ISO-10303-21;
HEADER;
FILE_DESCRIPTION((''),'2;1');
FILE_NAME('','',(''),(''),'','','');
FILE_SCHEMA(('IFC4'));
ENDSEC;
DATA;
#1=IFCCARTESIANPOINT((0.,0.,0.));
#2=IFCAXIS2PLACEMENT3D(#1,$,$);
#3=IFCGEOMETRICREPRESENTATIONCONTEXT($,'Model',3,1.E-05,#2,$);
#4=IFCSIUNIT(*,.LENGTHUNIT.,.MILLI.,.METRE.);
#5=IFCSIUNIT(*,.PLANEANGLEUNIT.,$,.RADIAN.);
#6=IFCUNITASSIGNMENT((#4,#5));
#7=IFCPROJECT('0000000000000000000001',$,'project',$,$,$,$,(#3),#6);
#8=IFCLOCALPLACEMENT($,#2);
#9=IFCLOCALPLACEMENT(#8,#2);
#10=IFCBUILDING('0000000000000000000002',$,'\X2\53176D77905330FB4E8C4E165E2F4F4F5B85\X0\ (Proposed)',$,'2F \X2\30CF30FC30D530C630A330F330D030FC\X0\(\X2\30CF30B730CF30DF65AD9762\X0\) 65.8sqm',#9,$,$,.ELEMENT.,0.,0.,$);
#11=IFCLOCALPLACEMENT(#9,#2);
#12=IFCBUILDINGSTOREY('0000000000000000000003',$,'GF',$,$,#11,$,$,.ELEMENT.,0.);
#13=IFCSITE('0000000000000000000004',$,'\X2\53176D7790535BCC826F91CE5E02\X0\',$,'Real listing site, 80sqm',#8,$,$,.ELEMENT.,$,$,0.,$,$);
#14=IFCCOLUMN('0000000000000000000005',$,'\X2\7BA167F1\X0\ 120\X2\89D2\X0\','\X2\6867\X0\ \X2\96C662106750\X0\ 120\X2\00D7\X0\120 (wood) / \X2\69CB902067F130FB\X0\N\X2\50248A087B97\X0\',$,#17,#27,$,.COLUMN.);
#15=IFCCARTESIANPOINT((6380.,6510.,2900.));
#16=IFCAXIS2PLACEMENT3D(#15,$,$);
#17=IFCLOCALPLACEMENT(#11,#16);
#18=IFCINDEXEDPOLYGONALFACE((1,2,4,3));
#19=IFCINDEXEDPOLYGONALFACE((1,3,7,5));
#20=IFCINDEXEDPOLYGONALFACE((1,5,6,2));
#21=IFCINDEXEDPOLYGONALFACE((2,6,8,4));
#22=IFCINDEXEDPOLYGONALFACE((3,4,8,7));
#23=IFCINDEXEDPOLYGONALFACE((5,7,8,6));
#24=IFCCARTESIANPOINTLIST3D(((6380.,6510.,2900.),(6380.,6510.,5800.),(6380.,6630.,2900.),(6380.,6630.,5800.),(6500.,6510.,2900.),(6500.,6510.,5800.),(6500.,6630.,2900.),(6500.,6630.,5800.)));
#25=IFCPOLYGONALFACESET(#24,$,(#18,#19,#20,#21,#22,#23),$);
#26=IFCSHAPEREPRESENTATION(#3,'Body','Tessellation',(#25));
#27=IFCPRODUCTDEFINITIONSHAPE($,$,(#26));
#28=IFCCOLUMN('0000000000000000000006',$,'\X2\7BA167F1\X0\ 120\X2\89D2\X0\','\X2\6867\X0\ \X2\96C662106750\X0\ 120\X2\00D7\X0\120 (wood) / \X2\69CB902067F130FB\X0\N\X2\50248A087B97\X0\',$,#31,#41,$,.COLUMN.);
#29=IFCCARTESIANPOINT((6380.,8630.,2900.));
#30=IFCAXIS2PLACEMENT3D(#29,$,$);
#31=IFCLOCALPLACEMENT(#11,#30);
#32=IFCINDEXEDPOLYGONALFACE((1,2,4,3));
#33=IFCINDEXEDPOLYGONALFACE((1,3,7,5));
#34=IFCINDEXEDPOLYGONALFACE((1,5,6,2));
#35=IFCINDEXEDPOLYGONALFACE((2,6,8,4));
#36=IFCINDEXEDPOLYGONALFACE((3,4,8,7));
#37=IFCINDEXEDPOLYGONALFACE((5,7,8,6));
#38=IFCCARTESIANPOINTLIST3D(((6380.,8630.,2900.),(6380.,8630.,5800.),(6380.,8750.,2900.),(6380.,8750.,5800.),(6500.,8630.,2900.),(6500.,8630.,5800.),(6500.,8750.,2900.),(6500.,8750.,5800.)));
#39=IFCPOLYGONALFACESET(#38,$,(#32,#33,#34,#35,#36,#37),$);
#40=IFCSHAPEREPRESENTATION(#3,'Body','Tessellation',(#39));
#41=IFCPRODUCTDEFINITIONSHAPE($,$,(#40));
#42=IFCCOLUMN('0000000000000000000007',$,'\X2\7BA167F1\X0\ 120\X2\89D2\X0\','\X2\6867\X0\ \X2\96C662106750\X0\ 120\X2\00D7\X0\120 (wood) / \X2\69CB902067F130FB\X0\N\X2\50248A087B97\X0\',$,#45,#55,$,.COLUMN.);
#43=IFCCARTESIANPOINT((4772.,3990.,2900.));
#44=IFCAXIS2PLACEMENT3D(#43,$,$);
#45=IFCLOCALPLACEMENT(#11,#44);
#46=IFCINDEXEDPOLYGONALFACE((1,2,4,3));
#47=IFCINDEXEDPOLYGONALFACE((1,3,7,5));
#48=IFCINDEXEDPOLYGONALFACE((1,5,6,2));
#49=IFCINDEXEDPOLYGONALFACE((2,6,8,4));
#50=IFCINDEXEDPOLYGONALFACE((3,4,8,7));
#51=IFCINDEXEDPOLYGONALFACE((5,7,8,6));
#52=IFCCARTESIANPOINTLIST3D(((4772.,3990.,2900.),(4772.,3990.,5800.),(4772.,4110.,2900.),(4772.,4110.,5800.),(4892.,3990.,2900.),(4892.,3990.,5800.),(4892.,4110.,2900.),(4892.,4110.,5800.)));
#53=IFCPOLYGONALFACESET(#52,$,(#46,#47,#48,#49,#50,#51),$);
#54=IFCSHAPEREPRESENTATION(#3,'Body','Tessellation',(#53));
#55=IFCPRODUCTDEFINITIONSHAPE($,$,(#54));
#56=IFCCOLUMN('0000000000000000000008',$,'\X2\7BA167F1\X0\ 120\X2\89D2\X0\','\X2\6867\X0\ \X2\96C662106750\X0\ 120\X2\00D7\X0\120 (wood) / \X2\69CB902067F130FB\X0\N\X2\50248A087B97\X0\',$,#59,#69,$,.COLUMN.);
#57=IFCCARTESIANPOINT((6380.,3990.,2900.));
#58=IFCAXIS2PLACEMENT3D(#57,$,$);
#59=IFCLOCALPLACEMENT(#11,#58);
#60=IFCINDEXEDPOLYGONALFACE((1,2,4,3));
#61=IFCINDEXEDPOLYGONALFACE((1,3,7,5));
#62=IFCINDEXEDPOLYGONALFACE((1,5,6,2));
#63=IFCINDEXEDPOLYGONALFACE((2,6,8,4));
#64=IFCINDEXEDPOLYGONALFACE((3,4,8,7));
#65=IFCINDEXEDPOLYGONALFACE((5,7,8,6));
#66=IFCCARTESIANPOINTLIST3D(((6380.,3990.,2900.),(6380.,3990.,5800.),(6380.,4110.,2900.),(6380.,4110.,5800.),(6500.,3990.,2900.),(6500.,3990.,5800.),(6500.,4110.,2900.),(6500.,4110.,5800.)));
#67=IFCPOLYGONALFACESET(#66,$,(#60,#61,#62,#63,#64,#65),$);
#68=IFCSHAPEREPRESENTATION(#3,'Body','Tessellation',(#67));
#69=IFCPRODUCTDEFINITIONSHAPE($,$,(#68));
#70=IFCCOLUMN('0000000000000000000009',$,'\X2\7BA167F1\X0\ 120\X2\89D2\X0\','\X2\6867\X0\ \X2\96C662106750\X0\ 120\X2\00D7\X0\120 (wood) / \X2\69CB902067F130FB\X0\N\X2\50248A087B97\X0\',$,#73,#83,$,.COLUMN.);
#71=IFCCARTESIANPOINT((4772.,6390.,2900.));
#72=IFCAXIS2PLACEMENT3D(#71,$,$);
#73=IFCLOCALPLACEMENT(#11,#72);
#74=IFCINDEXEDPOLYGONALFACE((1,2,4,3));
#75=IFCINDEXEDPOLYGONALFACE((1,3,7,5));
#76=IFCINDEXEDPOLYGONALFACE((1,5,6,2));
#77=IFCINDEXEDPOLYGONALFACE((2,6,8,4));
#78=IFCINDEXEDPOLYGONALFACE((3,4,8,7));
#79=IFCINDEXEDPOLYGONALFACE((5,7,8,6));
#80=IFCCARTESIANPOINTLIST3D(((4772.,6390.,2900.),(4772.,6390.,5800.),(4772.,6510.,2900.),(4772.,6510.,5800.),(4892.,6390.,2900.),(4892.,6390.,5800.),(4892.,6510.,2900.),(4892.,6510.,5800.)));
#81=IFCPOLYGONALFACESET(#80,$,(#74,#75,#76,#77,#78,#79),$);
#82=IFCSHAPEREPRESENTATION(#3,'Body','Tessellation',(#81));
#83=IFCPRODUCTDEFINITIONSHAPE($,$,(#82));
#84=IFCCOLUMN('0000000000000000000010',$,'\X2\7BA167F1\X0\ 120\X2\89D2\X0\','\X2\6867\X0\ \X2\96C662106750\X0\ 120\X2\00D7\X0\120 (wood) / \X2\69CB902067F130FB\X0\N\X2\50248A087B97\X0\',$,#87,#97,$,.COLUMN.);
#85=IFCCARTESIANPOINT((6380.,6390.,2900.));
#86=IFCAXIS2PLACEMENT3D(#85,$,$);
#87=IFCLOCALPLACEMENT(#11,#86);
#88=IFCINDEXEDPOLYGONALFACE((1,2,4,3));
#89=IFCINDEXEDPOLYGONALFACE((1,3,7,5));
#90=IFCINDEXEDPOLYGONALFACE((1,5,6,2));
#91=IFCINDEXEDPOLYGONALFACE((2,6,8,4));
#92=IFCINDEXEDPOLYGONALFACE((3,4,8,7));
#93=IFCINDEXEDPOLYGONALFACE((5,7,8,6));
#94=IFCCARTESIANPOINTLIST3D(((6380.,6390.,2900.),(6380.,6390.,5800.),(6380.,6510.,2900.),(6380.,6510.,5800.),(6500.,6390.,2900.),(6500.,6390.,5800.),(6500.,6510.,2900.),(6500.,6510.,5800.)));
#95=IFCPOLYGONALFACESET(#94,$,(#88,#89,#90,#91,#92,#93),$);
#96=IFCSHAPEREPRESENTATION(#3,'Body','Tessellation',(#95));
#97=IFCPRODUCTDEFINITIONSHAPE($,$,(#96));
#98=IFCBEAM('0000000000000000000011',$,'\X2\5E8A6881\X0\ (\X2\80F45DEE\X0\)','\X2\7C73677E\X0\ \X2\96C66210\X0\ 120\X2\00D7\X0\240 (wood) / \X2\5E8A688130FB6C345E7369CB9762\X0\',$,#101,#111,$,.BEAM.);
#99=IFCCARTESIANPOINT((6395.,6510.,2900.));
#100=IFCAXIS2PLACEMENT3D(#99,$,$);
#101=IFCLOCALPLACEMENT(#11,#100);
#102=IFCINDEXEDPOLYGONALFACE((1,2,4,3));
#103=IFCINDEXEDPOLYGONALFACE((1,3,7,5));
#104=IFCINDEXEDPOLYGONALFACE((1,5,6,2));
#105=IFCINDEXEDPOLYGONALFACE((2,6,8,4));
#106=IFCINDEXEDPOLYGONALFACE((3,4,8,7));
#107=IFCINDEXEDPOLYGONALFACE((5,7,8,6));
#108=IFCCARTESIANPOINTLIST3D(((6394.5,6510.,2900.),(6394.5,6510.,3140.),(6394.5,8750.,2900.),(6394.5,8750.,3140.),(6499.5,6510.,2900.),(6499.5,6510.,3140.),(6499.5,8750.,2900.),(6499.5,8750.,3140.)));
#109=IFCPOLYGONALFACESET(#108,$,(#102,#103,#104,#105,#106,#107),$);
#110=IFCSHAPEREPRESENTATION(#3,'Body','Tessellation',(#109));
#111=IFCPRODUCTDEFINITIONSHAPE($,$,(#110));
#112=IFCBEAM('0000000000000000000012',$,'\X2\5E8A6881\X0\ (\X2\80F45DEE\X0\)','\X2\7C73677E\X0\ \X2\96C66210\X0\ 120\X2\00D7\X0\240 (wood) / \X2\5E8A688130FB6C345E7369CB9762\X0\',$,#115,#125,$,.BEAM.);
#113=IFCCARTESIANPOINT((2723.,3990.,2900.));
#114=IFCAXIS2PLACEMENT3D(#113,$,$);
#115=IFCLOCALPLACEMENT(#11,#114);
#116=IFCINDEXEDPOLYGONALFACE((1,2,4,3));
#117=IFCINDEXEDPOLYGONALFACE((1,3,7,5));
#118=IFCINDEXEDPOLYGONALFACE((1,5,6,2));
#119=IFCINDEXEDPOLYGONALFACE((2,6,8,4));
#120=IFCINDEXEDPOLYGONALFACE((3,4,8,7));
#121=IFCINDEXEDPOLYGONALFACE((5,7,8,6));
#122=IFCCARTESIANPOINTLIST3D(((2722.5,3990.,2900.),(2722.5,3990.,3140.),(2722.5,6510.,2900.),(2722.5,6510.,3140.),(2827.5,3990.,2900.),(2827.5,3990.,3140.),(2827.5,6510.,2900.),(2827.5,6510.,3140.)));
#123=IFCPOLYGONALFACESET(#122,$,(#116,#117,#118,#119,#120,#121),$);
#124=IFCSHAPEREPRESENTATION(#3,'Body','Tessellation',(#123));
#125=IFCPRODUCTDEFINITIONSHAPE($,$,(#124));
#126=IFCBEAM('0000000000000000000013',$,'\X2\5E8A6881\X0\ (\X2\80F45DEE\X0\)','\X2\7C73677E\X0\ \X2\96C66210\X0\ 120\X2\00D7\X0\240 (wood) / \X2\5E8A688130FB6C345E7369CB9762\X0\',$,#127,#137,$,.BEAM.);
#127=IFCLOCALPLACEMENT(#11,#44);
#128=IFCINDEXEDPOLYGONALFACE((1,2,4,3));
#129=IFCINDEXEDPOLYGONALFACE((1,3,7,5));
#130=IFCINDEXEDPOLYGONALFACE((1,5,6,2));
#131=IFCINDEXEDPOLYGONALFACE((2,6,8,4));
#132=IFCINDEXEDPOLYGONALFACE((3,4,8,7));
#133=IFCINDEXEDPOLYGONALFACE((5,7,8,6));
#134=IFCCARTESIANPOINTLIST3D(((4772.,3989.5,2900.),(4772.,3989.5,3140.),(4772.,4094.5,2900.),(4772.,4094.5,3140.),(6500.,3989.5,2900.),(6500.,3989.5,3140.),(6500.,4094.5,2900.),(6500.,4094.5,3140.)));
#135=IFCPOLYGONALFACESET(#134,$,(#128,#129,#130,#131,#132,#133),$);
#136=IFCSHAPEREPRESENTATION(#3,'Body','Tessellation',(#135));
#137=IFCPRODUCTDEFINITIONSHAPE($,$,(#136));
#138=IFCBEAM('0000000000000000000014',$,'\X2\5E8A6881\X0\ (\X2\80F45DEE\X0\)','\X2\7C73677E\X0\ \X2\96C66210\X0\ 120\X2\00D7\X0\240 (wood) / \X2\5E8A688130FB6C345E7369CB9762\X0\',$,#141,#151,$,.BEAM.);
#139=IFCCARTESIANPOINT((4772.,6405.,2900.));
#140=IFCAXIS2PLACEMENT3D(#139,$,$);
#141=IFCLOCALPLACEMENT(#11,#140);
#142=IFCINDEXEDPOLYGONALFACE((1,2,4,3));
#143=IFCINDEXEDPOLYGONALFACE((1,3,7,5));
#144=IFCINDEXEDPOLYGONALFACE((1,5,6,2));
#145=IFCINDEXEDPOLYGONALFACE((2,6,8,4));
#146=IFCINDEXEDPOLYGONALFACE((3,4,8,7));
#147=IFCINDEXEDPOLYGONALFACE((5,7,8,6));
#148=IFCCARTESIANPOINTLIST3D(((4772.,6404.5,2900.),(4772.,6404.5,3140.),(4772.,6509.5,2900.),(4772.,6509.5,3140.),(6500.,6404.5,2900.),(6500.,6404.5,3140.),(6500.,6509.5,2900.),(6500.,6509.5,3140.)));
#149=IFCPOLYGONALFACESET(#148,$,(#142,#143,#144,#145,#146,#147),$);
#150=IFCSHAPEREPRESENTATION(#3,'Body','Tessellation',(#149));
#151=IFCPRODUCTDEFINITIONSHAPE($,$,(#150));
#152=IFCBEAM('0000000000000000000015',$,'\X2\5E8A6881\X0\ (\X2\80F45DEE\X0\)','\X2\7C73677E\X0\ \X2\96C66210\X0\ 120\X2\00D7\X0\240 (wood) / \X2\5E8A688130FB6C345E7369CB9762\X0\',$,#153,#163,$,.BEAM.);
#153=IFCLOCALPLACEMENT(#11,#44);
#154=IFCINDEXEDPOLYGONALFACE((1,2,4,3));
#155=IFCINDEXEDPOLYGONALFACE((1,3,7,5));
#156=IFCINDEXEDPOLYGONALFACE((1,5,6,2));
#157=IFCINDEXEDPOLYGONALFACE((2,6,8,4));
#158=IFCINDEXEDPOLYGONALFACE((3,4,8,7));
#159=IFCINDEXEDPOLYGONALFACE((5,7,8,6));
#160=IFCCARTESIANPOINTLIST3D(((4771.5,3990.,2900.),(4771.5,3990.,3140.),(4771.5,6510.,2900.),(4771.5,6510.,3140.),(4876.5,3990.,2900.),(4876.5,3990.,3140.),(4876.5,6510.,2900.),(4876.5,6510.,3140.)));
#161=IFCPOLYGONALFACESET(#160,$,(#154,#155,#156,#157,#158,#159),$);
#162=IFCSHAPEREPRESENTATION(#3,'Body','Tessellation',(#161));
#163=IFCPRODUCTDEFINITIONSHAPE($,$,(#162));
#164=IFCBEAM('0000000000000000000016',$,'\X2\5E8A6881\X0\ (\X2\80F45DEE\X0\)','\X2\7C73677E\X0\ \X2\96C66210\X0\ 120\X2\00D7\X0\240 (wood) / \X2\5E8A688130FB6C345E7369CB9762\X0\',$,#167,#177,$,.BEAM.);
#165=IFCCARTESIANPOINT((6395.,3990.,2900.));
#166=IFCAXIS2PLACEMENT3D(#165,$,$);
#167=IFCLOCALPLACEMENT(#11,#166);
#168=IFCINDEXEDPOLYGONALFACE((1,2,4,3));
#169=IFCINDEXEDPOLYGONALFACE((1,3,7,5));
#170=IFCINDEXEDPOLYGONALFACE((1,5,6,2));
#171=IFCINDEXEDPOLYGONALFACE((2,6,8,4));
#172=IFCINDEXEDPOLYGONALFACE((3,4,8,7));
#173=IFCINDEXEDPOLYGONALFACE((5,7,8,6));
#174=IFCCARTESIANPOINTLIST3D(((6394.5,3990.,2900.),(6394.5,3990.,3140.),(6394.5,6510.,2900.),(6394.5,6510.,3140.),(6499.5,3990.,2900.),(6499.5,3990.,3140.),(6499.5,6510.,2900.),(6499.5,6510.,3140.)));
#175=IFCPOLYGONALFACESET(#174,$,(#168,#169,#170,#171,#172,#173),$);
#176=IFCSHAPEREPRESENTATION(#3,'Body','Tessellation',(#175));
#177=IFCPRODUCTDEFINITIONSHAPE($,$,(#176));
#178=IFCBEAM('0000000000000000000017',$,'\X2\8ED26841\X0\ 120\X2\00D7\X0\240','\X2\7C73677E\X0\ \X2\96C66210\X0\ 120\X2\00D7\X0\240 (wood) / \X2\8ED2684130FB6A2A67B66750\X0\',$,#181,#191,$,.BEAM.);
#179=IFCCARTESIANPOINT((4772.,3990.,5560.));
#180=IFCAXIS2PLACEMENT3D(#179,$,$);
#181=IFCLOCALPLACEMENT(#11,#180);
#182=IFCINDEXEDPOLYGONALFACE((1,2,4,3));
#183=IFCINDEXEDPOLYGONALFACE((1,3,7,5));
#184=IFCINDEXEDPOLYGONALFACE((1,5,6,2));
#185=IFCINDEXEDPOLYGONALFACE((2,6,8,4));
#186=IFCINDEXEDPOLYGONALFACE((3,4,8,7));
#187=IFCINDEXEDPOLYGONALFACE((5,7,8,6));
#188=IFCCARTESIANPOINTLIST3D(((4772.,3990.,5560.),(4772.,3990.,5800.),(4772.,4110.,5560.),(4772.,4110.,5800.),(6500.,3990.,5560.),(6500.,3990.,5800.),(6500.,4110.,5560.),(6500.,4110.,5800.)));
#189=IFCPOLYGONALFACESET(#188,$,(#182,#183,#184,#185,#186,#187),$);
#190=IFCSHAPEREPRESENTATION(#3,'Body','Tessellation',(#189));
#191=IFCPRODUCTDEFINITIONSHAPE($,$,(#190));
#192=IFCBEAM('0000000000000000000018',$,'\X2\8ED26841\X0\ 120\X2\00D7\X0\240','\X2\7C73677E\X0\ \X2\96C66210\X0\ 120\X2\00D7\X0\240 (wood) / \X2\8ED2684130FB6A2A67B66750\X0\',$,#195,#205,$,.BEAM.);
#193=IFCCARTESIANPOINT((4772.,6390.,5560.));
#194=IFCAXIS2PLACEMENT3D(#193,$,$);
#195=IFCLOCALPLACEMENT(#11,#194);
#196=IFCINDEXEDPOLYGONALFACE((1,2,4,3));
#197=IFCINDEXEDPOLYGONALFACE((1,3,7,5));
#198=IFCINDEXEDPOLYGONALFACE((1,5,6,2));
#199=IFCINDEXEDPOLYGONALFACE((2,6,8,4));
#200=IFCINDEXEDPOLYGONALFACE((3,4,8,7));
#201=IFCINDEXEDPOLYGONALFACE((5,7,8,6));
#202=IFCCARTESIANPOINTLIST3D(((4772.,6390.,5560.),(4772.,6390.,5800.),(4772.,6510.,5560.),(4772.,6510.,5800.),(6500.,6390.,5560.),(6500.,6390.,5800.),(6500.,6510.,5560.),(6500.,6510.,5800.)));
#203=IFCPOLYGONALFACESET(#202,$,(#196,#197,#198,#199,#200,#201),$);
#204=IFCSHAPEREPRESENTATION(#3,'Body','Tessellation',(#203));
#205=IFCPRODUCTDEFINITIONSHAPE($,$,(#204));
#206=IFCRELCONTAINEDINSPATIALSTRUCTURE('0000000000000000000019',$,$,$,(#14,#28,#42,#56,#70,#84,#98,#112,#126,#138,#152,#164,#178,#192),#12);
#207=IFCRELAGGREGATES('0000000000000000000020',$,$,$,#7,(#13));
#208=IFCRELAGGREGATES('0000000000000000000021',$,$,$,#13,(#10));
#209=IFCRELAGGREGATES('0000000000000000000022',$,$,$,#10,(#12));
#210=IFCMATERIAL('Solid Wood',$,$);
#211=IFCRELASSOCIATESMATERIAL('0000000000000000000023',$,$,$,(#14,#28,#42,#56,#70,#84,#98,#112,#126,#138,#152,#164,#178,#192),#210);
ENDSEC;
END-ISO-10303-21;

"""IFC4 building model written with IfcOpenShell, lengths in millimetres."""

from ifc_helpers import new_model, si_unit, frame, frame_2d, origin, place, context, project, spatial, rectangle, extrude, material, element, save


model = new_model("IFC4")

# Units and contexts
model_context = context("Model", 3, precision=1e-05, world=origin())
ifc_project = project(units=[si_unit("LENGTHUNIT", "METRE", prefix="MILLI"), si_unit("PLANEANGLEUNIT", "RADIAN")], contexts=[model_context])

# Site, building, storey
site_placement = place(None, origin())
site = spatial("IfcSite", under=ifc_project, at=site_placement, Name="北海道富良野市", ObjectType="Real listing site, 80sqm", CompositionType="ELEMENT", RefElevation=0.0)
building_placement = place(site_placement, origin())
building = spatial("IfcBuilding", under=site, at=building_placement, Name="北海道・二世帯住宅 (Proposed)", ObjectType="2F ハーフティンバー(ハシハミ断面) 65.8sqm", CompositionType="ELEMENT", ElevationOfRefHeight=0.0, ElevationOfTerrain=0.0)
storey_placement = place(building_placement, origin())
storey = spatial("IfcBuildingStorey", under=building, at=storey_placement, Name="GF", CompositionType="ELEMENT", Elevation=0.0)

# Columns
ifc_material_1 = material(Name="Solid Wood")
column_1_placement = place(storey_placement, frame((6380.0, 6510.0, 2900.0)))
element("IfcColumn", 1, at=column_1_placement, inside=storey, material=ifc_material_1, Name="管柱 120角", Description="桧 集成材 120×120 (wood) / 構造柱・N値計算", PredefinedType="COLUMN", context=model_context, shape_type="SweptSolid", body=[
    extrude(rectangle(XDim=120.0, YDim=120.0, at=frame_2d((60.0, 60.0))), frame((6380.0, 6510.0, 2900.0)), (0.0, 0.0, 1.0), 2900.0),
])
column_2_placement = place(storey_placement, frame((6380.0, 8630.0, 2900.0)))
element("IfcColumn", 2, at=column_2_placement, inside=storey, material=ifc_material_1, Name="管柱 120角", Description="桧 集成材 120×120 (wood) / 構造柱・N値計算", PredefinedType="COLUMN", context=model_context, shape_type="SweptSolid", body=[
    extrude(rectangle(XDim=120.0, YDim=120.0, at=frame_2d((60.0, 60.0))), frame((6380.0, 8630.0, 2900.0)), (0.0, 0.0, 1.0), 2900.0),
])
column_3_placement = place(storey_placement, frame((4772.0, 3990.0, 2900.0)))
element("IfcColumn", 3, at=column_3_placement, inside=storey, material=ifc_material_1, Name="管柱 120角", Description="桧 集成材 120×120 (wood) / 構造柱・N値計算", PredefinedType="COLUMN", context=model_context, shape_type="SweptSolid", body=[
    extrude(rectangle(XDim=120.0, YDim=120.0, at=frame_2d((60.0, 60.0))), frame((4772.0, 3990.0, 2900.0)), (0.0, 0.0, 1.0), 2900.0),
])
column_4_placement = place(storey_placement, frame((6380.0, 3990.0, 2900.0)))
element("IfcColumn", 4, at=column_4_placement, inside=storey, material=ifc_material_1, Name="管柱 120角", Description="桧 集成材 120×120 (wood) / 構造柱・N値計算", PredefinedType="COLUMN", context=model_context, shape_type="SweptSolid", body=[
    extrude(rectangle(XDim=120.0, YDim=120.0, at=frame_2d((60.0, 60.0))), frame((6380.0, 3990.0, 2900.0)), (0.0, 0.0, 1.0), 2900.0),
])
column_5_placement = place(storey_placement, frame((4772.0, 6390.0, 2900.0)))
element("IfcColumn", 5, at=column_5_placement, inside=storey, material=ifc_material_1, Name="管柱 120角", Description="桧 集成材 120×120 (wood) / 構造柱・N値計算", PredefinedType="COLUMN", context=model_context, shape_type="SweptSolid", body=[
    extrude(rectangle(XDim=120.0, YDim=120.0, at=frame_2d((60.0, 60.0))), frame((4772.0, 6390.0, 2900.0)), (0.0, 0.0, 1.0), 2900.0),
])
column_6_placement = place(storey_placement, frame((6380.0, 6390.0, 2900.0)))
element("IfcColumn", 6, at=column_6_placement, inside=storey, material=ifc_material_1, Name="管柱 120角", Description="桧 集成材 120×120 (wood) / 構造柱・N値計算", PredefinedType="COLUMN", context=model_context, shape_type="SweptSolid", body=[
    extrude(rectangle(XDim=120.0, YDim=120.0, at=frame_2d((60.0, 60.0))), frame((6380.0, 6390.0, 2900.0)), (0.0, 0.0, 1.0), 2900.0),
])

# Beams
beam_1_placement = place(storey_placement, frame((6395.0, 6510.0, 2900.0)))
element("IfcBeam", 7, at=beam_1_placement, inside=storey, material=ifc_material_1, Name="床梁 (胴差)", Description="米松 集成 120×240 (wood) / 床梁・水平構面", PredefinedType="BEAM", context=model_context, shape_type="SweptSolid", body=[
    extrude(rectangle(XDim=105.0, YDim=2240.0, at=frame_2d((52.0, 1120.0))), frame((6395.0, 6510.0, 2900.0)), (0.0, 0.0, 1.0), 240.0),
])
beam_2_placement = place(storey_placement, frame((2723.0, 3990.0, 2900.0)))
element("IfcBeam", 8, at=beam_2_placement, inside=storey, material=ifc_material_1, Name="床梁 (胴差)", Description="米松 集成 120×240 (wood) / 床梁・水平構面", PredefinedType="BEAM", context=model_context, shape_type="SweptSolid", body=[
    extrude(rectangle(XDim=105.0, YDim=2520.0, at=frame_2d((52.0, 1260.0))), frame((2723.0, 3990.0, 2900.0)), (0.0, 0.0, 1.0), 240.0),
])
beam_3_placement = place(storey_placement, frame((4772.0, 3990.0, 2900.0)))
element("IfcBeam", 9, at=beam_3_placement, inside=storey, material=ifc_material_1, Name="床梁 (胴差)", Description="米松 集成 120×240 (wood) / 床梁・水平構面", PredefinedType="BEAM", context=model_context, shape_type="SweptSolid", body=[
    extrude(rectangle(XDim=1728.0, YDim=105.0, at=frame_2d((864.0, 52.0))), frame((4772.0, 3990.0, 2900.0)), (0.0, 0.0, 1.0), 240.0),
])
beam_4_placement = place(storey_placement, frame((4772.0, 6405.0, 2900.0)))
element("IfcBeam", 10, at=beam_4_placement, inside=storey, material=ifc_material_1, Name="床梁 (胴差)", Description="米松 集成 120×240 (wood) / 床梁・水平構面", PredefinedType="BEAM", context=model_context, shape_type="SweptSolid", body=[
    extrude(rectangle(XDim=1728.0, YDim=105.0, at=frame_2d((864.0, 52.0))), frame((4772.0, 6405.0, 2900.0)), (0.0, 0.0, 1.0), 240.0),
])
beam_5_placement = place(storey_placement, frame((4772.0, 3990.0, 2900.0)))
element("IfcBeam", 11, at=beam_5_placement, inside=storey, material=ifc_material_1, Name="床梁 (胴差)", Description="米松 集成 120×240 (wood) / 床梁・水平構面", PredefinedType="BEAM", context=model_context, shape_type="SweptSolid", body=[
    extrude(rectangle(XDim=105.0, YDim=2520.0, at=frame_2d((52.0, 1260.0))), frame((4772.0, 3990.0, 2900.0)), (0.0, 0.0, 1.0), 240.0),
])
beam_6_placement = place(storey_placement, frame((6395.0, 3990.0, 2900.0)))
element("IfcBeam", 12, at=beam_6_placement, inside=storey, material=ifc_material_1, Name="床梁 (胴差)", Description="米松 集成 120×240 (wood) / 床梁・水平構面", PredefinedType="BEAM", context=model_context, shape_type="SweptSolid", body=[
    extrude(rectangle(XDim=105.0, YDim=2520.0, at=frame_2d((52.0, 1260.0))), frame((6395.0, 3990.0, 2900.0)), (0.0, 0.0, 1.0), 240.0),
])
beam_7_placement = place(storey_placement, frame((4772.0, 3990.0, 5560.0)))
element("IfcBeam", 13, at=beam_7_placement, inside=storey, material=ifc_material_1, Name="軒桁 120×240", Description="米松 集成 120×240 (wood) / 軒桁・横架材", PredefinedType="BEAM", context=model_context, shape_type="SweptSolid", body=[
    extrude(rectangle(XDim=1728.0, YDim=120.0, at=frame_2d((864.0, 60.0))), frame((4772.0, 3990.0, 5560.0)), (0.0, 0.0, 1.0), 240.0),
])
beam_8_placement = place(storey_placement, frame((4772.0, 6390.0, 5560.0)))
element("IfcBeam", 14, at=beam_8_placement, inside=storey, material=ifc_material_1, Name="軒桁 120×240", Description="米松 集成 120×240 (wood) / 軒桁・横架材", PredefinedType="BEAM", context=model_context, shape_type="SweptSolid", body=[
    extrude(rectangle(XDim=1728.0, YDim=120.0, at=frame_2d((864.0, 60.0))), frame((4772.0, 6390.0, 5560.0)), (0.0, 0.0, 1.0), 240.0),
])

save(model, "model.ifc")
